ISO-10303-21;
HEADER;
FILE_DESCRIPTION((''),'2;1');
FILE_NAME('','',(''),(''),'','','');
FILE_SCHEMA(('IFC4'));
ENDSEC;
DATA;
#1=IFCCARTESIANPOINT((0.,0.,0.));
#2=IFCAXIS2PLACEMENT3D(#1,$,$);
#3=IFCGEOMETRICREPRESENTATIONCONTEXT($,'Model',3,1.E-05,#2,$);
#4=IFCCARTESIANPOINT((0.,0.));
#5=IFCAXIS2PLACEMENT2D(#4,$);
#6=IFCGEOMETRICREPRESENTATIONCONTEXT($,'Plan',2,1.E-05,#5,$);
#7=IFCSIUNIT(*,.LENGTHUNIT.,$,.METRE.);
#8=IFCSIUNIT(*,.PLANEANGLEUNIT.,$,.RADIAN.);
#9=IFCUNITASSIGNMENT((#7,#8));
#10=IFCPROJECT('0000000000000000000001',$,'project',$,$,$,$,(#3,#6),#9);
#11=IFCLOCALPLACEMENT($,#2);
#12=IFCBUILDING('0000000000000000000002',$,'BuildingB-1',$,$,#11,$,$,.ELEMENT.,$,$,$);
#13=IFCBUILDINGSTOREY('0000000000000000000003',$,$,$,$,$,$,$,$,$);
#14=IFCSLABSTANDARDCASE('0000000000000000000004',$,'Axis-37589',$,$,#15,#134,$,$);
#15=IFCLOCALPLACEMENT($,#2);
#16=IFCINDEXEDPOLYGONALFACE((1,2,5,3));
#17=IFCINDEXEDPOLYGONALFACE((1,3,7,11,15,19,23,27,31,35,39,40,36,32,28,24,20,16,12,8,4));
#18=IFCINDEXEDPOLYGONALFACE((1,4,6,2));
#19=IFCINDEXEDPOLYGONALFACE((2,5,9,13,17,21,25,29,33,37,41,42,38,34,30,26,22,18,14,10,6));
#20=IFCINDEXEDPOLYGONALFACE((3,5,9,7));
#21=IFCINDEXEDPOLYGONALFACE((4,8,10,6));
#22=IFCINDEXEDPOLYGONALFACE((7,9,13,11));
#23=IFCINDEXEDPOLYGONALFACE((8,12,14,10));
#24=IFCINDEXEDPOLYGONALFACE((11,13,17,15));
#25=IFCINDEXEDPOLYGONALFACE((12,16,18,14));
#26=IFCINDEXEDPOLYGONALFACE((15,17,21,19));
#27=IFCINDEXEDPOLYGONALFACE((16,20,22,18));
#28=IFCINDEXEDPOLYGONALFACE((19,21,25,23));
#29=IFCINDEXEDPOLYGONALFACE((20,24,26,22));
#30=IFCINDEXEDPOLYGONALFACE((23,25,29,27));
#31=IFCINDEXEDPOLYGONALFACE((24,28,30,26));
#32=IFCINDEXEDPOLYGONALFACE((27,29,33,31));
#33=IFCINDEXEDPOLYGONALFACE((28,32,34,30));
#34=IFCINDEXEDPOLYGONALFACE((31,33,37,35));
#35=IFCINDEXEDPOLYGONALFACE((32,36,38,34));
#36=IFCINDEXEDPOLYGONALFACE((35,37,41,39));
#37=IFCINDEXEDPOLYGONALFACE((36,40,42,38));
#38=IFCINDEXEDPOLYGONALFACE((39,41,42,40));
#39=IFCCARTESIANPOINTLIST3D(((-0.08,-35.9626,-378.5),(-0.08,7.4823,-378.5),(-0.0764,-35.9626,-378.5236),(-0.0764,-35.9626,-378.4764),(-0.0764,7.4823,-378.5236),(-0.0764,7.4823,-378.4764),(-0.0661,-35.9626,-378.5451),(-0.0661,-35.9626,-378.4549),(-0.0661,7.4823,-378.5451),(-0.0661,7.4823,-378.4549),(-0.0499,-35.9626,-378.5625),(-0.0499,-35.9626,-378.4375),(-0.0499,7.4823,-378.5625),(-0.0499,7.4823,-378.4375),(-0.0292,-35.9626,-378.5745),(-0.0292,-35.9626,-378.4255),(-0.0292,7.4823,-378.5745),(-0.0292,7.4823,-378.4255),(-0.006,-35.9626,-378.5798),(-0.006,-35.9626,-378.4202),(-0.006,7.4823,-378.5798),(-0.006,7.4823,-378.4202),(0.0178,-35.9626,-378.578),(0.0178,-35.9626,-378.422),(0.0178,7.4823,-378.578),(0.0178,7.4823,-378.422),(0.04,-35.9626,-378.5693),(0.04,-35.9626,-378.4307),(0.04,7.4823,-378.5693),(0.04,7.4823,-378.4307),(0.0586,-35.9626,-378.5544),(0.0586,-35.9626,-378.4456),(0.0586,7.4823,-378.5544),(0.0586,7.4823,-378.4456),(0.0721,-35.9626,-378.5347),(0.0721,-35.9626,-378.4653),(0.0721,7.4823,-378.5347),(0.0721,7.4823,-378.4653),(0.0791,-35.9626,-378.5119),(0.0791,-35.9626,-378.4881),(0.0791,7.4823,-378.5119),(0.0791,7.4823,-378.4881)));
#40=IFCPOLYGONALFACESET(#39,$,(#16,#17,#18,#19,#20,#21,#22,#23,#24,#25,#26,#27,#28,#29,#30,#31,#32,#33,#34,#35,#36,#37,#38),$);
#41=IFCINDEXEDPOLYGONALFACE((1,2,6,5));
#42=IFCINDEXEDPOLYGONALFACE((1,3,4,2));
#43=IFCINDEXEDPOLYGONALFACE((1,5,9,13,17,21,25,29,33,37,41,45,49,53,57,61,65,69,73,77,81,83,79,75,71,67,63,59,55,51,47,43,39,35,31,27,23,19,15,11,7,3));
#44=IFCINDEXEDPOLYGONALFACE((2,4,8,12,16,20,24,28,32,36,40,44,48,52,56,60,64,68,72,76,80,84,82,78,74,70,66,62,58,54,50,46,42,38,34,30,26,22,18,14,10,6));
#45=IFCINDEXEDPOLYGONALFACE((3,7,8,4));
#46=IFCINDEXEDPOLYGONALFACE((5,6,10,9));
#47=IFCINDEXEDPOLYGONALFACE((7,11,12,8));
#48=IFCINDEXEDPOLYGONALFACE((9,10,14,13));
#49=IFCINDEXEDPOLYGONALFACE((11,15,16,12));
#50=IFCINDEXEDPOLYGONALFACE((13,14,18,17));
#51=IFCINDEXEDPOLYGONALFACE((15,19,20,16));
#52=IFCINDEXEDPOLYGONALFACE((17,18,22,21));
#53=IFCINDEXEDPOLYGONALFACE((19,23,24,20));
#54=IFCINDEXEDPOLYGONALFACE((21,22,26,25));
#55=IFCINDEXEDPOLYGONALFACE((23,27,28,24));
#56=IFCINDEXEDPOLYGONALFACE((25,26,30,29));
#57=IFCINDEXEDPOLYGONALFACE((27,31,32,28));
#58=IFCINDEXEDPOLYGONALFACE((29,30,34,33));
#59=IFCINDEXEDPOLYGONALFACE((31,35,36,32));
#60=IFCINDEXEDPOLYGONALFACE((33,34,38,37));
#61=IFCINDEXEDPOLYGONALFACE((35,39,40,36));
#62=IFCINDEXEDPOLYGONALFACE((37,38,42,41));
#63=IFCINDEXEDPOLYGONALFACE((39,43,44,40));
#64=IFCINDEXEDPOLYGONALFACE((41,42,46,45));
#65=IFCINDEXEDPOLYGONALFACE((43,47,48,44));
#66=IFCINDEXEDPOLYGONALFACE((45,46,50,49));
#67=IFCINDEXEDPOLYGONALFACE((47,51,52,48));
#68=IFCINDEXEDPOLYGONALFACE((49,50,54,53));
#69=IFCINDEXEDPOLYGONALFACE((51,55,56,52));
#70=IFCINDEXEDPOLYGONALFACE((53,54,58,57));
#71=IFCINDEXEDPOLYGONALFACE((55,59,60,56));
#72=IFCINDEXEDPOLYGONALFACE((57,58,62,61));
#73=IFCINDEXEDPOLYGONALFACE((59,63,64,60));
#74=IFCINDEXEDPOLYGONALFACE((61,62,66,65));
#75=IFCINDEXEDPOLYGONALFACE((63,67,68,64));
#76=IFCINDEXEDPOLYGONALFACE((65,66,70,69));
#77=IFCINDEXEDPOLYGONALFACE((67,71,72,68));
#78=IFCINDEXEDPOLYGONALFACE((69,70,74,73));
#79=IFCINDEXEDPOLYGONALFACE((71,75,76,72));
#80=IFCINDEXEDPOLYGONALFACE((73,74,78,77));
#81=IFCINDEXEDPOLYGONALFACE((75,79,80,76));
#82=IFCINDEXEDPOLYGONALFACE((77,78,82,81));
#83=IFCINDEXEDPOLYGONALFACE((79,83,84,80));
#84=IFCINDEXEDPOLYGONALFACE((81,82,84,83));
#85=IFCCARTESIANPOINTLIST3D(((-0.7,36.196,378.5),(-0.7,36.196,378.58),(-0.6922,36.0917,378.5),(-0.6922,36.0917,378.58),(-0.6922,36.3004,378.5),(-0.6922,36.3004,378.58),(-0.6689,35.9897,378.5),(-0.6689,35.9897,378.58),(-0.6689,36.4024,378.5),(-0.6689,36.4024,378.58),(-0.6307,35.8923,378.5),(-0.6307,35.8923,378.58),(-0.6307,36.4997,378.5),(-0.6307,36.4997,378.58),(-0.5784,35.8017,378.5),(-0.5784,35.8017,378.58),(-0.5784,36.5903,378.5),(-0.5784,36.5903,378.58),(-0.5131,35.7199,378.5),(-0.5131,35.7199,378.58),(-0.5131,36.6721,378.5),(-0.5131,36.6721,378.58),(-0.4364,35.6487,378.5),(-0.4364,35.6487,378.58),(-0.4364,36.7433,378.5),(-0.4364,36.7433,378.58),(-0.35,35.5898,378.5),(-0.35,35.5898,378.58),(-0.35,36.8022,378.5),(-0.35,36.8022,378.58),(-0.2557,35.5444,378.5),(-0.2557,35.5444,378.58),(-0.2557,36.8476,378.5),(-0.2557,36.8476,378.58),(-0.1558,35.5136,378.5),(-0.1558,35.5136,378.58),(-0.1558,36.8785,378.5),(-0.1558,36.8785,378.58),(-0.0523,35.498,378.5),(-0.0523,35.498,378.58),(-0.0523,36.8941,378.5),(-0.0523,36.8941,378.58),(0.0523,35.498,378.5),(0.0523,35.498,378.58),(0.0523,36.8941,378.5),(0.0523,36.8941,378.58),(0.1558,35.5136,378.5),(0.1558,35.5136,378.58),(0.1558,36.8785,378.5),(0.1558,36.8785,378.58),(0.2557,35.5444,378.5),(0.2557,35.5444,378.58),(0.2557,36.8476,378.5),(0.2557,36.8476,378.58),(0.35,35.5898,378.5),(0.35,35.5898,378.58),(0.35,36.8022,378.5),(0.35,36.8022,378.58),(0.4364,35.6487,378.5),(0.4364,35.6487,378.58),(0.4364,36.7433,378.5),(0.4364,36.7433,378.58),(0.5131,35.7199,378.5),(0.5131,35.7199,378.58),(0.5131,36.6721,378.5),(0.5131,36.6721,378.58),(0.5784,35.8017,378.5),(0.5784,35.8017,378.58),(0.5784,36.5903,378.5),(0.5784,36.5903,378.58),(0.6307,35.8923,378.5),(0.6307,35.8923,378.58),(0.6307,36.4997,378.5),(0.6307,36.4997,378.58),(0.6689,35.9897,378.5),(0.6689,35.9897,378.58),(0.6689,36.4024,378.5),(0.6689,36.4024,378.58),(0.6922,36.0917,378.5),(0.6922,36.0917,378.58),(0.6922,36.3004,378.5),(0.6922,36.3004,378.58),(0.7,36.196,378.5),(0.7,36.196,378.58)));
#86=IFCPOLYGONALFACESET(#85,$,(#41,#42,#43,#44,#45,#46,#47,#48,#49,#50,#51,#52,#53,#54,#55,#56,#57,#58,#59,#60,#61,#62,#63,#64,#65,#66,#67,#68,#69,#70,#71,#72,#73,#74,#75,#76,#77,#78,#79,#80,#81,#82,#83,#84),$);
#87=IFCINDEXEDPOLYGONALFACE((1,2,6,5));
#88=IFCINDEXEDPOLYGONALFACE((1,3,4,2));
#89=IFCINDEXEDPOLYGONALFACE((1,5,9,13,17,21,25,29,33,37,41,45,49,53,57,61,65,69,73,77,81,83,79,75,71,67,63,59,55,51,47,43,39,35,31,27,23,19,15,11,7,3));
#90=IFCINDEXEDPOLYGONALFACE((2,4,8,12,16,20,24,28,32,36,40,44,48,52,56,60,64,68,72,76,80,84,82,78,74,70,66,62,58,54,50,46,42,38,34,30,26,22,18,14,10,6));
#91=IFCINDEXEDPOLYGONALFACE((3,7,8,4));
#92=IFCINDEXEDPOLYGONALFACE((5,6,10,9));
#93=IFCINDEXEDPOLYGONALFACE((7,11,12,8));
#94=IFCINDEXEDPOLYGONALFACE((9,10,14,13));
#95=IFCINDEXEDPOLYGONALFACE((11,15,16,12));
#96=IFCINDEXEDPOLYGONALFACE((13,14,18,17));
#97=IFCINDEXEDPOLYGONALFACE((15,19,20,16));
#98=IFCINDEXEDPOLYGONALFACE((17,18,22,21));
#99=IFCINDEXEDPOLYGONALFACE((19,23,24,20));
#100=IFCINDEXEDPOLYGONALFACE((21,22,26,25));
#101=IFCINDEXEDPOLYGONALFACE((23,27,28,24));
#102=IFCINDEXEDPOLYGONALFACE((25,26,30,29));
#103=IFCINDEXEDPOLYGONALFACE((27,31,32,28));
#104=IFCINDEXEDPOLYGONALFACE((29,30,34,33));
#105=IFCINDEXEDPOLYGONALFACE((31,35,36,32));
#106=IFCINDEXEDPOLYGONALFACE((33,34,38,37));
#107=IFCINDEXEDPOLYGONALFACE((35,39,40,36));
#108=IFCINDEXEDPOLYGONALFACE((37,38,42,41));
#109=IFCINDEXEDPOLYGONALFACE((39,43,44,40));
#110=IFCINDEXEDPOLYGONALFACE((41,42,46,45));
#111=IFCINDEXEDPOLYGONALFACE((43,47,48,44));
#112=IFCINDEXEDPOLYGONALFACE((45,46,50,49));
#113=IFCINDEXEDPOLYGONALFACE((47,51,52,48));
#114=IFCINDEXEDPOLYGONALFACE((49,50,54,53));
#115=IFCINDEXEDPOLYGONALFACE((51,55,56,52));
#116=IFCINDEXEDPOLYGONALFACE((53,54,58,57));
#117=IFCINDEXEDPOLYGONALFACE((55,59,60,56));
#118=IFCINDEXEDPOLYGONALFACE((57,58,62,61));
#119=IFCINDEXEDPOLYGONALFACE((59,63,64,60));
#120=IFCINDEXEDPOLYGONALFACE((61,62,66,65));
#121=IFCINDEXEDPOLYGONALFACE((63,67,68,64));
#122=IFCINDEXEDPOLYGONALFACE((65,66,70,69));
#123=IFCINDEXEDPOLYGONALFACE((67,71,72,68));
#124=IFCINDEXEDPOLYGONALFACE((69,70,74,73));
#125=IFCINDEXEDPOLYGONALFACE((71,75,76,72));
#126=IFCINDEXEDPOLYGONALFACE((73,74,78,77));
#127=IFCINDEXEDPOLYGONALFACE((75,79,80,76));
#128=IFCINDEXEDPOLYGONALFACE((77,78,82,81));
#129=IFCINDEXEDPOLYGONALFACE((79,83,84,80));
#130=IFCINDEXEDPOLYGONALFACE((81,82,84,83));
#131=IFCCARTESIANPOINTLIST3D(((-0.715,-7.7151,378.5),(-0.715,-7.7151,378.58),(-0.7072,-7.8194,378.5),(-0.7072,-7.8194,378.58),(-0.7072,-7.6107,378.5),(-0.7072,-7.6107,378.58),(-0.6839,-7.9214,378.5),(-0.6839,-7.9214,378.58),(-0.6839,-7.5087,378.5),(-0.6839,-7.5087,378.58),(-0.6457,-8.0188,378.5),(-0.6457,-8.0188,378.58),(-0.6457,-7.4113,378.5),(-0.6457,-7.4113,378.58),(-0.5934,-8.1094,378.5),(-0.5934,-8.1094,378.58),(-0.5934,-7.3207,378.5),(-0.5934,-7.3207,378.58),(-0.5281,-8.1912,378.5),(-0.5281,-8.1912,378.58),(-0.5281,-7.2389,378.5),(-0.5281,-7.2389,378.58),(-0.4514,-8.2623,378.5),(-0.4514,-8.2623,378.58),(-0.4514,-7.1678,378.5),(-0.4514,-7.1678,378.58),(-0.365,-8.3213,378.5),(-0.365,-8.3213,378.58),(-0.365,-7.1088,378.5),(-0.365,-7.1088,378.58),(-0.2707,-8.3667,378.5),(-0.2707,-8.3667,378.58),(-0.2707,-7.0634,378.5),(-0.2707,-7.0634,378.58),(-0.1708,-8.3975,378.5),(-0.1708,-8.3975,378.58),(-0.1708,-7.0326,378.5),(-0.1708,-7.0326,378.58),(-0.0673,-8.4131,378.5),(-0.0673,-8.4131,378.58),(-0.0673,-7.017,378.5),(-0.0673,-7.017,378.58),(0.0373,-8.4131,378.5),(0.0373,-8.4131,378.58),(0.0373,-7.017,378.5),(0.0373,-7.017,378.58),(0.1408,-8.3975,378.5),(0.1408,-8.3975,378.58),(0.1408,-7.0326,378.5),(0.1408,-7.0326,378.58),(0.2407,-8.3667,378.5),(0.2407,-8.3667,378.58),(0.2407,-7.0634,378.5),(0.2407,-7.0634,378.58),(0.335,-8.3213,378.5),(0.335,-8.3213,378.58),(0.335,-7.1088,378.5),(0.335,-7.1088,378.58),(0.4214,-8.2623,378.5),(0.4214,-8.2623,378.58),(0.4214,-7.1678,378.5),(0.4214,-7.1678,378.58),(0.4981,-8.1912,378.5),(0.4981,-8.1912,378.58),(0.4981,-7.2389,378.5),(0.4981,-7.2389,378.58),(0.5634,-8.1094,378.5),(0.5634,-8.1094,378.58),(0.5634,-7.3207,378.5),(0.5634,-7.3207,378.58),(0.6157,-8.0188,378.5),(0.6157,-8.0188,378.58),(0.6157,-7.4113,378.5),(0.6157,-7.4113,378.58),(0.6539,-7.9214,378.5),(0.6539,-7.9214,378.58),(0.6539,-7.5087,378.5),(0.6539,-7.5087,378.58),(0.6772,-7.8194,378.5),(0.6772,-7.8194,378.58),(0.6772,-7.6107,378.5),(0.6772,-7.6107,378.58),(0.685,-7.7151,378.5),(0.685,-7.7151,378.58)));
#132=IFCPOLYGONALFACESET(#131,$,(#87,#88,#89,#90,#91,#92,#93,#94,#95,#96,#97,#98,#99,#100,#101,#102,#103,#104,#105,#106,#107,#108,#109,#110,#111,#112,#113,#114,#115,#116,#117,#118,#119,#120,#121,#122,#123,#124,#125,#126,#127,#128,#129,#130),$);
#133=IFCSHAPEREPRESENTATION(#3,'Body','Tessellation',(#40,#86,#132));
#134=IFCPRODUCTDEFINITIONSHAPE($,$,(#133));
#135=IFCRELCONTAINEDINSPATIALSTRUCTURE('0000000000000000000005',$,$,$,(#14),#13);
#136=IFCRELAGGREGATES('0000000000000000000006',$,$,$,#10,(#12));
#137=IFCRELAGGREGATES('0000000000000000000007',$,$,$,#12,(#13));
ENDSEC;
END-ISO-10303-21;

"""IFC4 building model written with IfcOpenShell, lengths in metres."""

from ifc_helpers import new_model, entity, si_unit, frame, origin, origin_2d, place, context, project, spatial, circle, extrude, element, save


model = new_model("IFC4")

# Units and contexts
model_context = context("Model", 3, precision=1e-05, world=origin())
plan_context = context("Plan", 2, precision=1e-05, world=origin_2d())
ifc_project = project(units=[si_unit("LENGTHUNIT", "METRE"), si_unit("PLANEANGLEUNIT", "RADIAN")], contexts=[model_context, plan_context])

# Building, storey
building_placement = place(None, origin())
building = spatial("IfcBuilding", under=ifc_project, at=building_placement, Name="BuildingB-1", CompositionType="ELEMENT")
storey = spatial("IfcBuildingStorey", under=building)

# Slab
element("IfcSlabStandardCase", 1, inside=storey, Name="Axis-37589", context=model_context, shape_type="AdvancedSweptSolid", body=[
    entity("IfcSurfaceCurveSweptAreaSolid", entity("IfcCircleProfileDef", "AREA", None, None, 0.08), None, entity("IfcPolyline", [entity("IfcCartesianPoint", [0.0, 35.9626, 378.5]), entity("IfcCartesianPoint", [0.0, -7.4823, 378.5])]), None, None, entity("IfcPlane", entity("IfcAxis2Placement3D", entity("IfcCartesianPoint", [0.0, 35.9626, 378.5]), entity("IfcDirection", [0.0, 0.0, 1.0]), entity("IfcDirection", [1.0, 0.0, 0.0])))),
    extrude(circle(Radius=0.7), frame((0.0, 36.196, 378.5)), (0.0, 0.0, 1.0), 0.08),
    extrude(circle(Radius=0.7), frame((-0.015, -7.7151, 378.5)), (0.0, 0.0, 1.0), 0.08),
])

save(model, "model.ifc")
